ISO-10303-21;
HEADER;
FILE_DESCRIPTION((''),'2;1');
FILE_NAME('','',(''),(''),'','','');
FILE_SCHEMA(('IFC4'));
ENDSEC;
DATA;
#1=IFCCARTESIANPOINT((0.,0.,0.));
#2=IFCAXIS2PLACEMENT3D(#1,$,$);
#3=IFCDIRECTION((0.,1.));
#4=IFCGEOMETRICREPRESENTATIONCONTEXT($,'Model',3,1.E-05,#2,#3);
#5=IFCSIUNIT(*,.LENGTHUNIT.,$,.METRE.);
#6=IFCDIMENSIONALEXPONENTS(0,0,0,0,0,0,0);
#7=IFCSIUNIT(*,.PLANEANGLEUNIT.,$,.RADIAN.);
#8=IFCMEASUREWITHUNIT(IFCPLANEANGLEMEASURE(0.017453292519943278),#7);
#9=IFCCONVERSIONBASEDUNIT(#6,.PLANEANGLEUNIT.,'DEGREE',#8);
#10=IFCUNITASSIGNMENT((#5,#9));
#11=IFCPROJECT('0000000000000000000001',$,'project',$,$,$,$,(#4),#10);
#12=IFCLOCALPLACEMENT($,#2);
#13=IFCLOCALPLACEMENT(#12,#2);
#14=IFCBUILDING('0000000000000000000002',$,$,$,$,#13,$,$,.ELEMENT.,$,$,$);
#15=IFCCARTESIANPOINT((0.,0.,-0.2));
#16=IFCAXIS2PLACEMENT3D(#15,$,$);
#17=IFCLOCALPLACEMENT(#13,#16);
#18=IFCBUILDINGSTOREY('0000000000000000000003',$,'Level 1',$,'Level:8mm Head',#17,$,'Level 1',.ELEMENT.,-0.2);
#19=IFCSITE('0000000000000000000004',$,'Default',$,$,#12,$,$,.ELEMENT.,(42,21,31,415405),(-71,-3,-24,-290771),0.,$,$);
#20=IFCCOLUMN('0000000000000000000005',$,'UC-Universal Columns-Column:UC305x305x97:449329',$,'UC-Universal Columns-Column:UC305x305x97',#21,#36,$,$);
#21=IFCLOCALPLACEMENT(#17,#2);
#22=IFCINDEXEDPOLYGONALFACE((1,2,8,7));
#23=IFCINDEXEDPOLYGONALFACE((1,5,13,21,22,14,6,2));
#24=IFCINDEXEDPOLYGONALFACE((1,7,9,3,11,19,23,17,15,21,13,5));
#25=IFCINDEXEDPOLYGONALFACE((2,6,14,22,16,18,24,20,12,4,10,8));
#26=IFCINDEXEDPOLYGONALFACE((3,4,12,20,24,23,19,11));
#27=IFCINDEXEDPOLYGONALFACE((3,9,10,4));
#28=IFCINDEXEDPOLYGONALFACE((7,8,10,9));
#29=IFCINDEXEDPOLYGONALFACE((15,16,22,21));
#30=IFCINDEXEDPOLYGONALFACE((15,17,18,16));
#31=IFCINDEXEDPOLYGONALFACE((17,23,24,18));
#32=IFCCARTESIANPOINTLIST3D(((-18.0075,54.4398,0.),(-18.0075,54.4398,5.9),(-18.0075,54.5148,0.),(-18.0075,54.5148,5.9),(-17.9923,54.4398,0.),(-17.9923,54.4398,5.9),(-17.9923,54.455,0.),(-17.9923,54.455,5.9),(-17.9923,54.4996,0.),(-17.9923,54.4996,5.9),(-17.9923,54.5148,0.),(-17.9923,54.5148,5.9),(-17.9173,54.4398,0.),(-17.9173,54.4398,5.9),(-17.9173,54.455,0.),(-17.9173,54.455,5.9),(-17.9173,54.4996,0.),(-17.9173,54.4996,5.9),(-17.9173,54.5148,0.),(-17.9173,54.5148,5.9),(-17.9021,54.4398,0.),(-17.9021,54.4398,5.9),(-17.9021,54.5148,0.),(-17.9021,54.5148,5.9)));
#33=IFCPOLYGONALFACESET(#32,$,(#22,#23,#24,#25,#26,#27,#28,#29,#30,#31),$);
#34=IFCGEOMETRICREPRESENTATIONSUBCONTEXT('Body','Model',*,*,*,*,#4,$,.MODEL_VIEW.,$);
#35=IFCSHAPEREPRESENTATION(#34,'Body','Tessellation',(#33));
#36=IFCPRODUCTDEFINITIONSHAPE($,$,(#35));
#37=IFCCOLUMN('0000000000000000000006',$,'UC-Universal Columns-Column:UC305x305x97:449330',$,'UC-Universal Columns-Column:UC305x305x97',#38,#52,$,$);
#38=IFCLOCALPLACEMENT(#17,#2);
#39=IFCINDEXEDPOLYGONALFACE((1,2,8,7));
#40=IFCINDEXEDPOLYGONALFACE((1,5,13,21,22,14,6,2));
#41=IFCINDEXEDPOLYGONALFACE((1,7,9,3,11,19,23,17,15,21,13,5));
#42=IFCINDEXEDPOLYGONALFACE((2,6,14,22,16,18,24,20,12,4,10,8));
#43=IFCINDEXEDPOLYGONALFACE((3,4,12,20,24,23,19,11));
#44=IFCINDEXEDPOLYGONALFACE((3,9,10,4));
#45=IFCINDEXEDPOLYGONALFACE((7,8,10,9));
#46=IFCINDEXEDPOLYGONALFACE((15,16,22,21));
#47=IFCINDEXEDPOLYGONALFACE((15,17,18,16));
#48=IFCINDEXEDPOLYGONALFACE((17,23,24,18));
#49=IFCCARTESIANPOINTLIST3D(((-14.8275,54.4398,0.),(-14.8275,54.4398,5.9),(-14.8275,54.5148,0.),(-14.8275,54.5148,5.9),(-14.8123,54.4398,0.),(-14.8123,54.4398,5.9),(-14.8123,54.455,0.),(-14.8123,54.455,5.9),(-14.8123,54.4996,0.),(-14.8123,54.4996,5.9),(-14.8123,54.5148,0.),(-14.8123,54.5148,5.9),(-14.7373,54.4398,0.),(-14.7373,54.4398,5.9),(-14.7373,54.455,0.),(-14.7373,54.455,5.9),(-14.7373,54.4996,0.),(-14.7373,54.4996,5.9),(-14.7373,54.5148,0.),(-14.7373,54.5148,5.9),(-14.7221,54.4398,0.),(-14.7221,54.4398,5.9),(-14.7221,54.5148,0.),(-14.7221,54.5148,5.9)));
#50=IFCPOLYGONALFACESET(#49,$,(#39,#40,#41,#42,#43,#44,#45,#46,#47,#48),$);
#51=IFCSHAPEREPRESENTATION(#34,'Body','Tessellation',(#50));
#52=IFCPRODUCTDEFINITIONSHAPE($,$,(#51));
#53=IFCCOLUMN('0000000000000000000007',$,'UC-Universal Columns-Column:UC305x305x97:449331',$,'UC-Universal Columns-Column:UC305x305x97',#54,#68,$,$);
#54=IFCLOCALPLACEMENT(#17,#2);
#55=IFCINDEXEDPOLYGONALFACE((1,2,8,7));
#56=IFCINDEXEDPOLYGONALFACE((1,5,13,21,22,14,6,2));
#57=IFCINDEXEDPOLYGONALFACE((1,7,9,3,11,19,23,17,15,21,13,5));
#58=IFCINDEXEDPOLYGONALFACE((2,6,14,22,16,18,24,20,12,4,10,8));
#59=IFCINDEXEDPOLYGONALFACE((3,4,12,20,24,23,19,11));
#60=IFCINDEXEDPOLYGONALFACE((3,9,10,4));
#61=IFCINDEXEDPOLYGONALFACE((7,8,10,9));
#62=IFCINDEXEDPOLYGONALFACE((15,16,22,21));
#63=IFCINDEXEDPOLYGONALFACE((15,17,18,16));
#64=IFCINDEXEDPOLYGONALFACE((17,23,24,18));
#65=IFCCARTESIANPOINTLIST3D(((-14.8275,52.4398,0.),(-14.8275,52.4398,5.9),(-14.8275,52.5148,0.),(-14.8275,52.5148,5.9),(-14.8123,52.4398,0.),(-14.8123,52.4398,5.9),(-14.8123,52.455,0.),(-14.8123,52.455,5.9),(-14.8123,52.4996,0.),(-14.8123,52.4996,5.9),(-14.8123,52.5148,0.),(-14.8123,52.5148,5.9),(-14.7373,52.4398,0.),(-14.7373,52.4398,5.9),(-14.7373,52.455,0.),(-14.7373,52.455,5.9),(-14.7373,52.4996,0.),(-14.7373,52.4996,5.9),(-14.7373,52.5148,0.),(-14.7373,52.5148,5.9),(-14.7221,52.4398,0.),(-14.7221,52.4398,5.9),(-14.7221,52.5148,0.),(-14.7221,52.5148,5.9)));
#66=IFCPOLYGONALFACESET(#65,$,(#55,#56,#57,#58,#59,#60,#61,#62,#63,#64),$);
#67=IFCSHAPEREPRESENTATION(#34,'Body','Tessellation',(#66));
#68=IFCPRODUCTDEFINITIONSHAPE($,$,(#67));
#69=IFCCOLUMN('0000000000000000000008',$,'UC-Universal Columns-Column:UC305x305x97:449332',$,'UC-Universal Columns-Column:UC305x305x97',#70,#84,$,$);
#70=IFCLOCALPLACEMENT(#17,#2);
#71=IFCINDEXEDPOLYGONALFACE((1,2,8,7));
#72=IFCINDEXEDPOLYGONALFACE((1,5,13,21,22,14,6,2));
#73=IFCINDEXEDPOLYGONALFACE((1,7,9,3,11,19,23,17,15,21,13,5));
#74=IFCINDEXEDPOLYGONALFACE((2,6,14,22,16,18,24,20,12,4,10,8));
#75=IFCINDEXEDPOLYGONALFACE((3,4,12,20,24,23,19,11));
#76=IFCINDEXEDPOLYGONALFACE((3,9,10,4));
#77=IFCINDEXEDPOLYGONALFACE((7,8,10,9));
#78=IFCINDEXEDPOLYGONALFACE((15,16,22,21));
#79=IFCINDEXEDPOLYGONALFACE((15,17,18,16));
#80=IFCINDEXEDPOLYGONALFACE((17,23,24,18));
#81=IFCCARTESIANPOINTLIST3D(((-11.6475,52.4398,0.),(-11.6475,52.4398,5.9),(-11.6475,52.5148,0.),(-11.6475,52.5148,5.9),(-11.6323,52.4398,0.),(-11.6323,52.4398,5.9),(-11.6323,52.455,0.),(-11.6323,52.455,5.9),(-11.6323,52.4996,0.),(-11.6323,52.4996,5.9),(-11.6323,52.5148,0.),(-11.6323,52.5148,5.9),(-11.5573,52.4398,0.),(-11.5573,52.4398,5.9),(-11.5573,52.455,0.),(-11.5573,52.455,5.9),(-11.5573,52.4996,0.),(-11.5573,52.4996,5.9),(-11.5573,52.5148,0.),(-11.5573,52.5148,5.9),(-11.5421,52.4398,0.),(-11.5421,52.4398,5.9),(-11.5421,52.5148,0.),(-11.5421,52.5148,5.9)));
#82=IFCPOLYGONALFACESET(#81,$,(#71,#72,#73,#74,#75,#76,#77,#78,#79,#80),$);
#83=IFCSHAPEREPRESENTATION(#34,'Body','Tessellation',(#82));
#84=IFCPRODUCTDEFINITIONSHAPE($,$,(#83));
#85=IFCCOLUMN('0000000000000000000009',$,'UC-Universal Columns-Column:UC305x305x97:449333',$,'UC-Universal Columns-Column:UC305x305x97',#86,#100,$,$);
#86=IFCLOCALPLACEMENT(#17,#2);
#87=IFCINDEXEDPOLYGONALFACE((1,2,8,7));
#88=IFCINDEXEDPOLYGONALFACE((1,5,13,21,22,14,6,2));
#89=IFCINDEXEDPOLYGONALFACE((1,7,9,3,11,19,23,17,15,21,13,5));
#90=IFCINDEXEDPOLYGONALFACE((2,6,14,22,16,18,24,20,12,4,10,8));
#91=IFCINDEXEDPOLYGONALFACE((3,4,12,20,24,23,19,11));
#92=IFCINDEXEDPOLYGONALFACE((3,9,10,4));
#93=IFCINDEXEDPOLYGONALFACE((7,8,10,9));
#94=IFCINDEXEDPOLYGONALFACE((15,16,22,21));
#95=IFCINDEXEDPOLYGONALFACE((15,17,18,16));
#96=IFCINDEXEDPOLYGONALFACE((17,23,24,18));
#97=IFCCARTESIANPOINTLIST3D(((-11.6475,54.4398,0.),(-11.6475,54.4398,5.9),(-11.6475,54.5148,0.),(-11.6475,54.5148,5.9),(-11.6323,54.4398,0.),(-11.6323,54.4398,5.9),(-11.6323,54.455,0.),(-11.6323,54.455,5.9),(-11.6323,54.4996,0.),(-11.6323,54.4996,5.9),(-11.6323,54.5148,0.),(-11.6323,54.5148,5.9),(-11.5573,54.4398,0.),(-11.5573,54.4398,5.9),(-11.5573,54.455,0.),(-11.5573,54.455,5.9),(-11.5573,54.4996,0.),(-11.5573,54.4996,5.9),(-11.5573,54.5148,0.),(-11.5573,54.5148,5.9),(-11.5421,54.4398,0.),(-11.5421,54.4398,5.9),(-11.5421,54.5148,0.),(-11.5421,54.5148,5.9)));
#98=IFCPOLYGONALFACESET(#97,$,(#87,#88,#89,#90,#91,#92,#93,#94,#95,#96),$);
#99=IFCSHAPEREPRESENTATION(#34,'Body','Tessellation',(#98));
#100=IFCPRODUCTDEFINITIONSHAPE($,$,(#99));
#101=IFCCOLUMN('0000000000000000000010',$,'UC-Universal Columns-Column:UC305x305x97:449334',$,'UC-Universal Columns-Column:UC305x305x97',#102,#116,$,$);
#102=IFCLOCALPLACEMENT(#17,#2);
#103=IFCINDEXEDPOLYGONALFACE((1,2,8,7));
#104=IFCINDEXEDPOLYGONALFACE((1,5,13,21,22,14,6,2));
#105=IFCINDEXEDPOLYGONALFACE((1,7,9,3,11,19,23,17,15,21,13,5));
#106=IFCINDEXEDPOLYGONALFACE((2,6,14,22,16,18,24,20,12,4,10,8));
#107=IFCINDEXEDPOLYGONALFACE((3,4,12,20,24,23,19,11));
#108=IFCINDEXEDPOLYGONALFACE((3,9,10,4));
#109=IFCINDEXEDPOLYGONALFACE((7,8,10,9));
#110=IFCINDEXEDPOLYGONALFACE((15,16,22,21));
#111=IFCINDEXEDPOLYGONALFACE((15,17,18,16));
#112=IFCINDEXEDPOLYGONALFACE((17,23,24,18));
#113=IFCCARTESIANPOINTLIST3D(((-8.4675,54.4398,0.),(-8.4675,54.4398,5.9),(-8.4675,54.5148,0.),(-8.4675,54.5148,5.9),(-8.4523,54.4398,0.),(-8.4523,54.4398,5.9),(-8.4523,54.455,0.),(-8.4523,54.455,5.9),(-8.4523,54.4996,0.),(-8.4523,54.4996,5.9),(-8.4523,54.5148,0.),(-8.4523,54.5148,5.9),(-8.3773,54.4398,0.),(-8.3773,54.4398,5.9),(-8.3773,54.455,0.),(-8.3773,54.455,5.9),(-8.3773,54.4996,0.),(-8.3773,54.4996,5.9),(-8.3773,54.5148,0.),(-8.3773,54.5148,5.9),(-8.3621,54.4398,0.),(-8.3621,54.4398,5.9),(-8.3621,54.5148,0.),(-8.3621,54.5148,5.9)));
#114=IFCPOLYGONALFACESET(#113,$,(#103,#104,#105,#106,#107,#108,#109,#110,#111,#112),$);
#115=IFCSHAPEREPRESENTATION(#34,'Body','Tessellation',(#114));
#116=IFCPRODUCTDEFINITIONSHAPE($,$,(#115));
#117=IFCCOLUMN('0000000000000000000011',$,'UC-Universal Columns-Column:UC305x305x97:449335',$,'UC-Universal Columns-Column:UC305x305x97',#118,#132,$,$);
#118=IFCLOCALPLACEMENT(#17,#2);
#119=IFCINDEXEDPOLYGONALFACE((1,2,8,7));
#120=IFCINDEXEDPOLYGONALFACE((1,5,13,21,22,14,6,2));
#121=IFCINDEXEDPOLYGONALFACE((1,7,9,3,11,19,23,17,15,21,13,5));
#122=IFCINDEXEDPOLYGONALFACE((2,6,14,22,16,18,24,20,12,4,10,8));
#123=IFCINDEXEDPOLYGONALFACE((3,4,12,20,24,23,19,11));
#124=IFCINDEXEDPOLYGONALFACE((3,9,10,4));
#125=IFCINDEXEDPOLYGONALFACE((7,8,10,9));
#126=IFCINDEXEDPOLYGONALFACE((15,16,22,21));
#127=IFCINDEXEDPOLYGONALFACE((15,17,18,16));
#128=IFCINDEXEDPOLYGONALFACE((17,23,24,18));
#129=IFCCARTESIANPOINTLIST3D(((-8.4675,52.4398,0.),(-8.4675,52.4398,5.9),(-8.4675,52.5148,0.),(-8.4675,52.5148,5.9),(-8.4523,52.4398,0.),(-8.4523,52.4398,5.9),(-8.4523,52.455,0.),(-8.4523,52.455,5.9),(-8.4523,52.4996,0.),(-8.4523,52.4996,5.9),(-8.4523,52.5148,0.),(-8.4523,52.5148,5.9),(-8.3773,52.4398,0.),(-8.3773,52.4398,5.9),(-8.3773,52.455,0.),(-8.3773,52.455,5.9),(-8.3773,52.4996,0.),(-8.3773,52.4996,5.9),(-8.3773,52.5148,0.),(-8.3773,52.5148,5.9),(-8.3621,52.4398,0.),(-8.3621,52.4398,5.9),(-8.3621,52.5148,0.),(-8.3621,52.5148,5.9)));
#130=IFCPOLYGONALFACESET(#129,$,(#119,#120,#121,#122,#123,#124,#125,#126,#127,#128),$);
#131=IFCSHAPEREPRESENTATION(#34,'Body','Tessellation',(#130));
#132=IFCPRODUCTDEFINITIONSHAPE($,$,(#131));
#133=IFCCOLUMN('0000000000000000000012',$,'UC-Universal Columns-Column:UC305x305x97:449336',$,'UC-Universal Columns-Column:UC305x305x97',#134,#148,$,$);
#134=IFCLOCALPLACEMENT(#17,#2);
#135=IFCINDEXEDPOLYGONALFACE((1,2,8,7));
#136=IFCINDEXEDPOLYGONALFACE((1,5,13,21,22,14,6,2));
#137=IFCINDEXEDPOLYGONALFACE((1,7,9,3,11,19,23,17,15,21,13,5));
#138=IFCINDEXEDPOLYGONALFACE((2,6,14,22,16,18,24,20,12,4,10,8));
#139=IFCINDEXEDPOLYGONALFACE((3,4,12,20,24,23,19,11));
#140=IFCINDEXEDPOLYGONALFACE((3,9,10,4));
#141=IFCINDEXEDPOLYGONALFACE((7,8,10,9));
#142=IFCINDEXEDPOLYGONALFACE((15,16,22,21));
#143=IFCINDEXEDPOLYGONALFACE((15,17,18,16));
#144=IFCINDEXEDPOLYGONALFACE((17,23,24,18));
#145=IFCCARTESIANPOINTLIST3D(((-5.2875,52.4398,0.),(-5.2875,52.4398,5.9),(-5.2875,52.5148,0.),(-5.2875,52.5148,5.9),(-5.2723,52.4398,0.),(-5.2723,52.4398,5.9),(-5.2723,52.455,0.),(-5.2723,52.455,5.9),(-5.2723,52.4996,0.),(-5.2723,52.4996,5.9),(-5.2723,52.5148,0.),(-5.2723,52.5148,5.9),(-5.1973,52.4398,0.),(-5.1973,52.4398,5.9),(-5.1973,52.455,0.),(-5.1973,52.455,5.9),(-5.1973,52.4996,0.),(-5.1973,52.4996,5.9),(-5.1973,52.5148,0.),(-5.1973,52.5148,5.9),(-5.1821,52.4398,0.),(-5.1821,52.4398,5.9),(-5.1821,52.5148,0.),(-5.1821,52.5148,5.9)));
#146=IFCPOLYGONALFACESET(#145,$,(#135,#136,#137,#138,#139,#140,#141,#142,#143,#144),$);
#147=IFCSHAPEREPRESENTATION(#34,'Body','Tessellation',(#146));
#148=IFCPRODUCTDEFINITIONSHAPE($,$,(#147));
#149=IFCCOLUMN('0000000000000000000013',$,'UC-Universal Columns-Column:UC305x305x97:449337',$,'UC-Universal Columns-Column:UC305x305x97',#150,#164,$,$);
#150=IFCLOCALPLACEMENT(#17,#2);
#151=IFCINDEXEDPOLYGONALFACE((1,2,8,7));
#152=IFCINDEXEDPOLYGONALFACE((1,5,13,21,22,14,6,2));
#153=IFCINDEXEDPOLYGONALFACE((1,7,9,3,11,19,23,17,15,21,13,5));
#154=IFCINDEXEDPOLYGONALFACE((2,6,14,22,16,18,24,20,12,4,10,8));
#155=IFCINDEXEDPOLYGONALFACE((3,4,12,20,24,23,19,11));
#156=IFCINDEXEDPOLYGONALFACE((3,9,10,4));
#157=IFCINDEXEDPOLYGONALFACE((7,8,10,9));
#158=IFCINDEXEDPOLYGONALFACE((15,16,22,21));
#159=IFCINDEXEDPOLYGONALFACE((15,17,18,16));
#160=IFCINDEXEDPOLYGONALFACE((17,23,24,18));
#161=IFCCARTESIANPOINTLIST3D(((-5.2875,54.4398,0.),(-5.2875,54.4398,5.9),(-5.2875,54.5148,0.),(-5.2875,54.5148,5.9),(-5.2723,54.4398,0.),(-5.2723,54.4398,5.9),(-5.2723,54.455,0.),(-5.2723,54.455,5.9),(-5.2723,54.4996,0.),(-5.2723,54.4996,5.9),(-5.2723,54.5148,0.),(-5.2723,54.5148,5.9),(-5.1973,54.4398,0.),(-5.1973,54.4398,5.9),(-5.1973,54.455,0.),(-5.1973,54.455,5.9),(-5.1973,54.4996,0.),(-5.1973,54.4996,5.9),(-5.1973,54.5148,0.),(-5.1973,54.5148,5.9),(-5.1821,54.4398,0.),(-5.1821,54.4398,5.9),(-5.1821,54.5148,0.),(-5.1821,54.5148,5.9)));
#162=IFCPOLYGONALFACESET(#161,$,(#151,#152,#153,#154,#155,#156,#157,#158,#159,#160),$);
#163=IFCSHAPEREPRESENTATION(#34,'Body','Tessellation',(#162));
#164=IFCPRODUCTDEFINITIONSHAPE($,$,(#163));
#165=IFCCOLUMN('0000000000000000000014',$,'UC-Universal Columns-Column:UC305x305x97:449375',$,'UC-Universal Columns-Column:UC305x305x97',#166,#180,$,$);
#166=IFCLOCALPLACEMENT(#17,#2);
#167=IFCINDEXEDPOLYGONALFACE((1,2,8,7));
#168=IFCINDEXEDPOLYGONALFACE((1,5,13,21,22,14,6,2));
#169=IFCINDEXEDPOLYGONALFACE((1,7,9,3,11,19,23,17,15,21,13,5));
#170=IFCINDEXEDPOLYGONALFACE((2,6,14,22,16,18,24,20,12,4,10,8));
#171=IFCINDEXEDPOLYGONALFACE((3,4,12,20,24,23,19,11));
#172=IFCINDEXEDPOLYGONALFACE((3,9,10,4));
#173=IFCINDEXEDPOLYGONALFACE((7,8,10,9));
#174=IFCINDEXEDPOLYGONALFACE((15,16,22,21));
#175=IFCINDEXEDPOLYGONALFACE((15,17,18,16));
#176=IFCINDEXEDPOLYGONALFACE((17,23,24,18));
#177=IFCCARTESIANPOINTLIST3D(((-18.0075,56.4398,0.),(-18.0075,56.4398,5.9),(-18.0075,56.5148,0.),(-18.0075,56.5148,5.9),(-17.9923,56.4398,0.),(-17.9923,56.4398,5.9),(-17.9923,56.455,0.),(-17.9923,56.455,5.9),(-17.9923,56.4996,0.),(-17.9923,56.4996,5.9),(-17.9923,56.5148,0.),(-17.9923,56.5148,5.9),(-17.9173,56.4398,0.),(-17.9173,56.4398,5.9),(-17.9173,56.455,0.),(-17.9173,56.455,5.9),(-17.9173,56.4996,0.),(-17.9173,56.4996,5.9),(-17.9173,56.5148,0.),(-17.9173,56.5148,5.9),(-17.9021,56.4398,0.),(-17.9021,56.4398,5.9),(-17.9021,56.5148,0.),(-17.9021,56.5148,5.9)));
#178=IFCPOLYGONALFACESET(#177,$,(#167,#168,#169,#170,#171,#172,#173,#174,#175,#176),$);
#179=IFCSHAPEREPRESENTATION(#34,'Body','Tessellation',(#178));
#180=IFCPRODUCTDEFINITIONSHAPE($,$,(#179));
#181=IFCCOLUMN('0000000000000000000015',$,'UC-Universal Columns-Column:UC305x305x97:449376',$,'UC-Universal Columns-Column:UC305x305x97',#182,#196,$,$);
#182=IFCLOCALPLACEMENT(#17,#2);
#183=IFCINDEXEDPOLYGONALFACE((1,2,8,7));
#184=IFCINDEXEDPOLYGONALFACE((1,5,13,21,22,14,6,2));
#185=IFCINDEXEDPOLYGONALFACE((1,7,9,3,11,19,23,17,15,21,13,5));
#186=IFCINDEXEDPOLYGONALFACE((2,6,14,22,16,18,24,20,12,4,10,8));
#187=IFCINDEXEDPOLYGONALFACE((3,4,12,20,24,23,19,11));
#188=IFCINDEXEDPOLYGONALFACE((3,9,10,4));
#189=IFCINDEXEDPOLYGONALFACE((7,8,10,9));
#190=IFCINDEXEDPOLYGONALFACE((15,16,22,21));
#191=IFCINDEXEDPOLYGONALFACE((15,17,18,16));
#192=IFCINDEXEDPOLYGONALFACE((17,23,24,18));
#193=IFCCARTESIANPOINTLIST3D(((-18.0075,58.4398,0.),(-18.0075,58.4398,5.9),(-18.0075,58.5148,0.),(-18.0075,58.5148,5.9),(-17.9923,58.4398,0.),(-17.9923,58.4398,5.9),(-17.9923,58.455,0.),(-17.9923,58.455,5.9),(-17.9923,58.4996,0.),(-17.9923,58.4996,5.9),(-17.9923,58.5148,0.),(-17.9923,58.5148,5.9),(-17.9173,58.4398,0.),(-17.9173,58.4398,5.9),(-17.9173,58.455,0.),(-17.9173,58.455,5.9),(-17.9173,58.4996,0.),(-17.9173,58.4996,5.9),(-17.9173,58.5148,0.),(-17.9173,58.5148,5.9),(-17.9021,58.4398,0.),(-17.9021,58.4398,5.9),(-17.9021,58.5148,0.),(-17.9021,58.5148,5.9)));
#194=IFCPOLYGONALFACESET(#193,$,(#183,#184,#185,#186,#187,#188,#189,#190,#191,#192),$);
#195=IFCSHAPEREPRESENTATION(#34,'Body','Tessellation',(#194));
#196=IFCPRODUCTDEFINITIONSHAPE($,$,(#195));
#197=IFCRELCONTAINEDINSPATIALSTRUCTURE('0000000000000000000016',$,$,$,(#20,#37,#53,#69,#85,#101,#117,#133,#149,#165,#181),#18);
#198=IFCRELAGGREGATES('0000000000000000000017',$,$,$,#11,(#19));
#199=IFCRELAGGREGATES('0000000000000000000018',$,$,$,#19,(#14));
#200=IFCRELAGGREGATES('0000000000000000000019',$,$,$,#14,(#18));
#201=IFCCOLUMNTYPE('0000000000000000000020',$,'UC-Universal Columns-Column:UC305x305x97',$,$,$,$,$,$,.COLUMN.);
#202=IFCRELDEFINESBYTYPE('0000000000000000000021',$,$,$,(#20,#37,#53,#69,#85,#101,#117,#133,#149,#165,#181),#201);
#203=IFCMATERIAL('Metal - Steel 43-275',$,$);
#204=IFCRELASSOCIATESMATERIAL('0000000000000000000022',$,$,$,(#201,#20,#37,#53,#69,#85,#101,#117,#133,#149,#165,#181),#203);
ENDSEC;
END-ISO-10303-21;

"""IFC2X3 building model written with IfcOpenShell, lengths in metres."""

from ifc_helpers import new_model, entity, si_unit, converted_unit, direction, frame, frame_2d, origin, place, context, subcontext, project, spatial, polyline, circle_curve, parameter, trimmed, segment, composite_curve, outline, extrude, source, transform, mapped, material, type_object, type_shapes, element, save


model = new_model("IFC2X3")

# Units and contexts
model_context = context("Model", 3, precision=1e-05, world=origin(), true_north=direction((0.0, 1.0)))
body_context = subcontext(model_context, "Body", "Model", "MODEL_VIEW")
ifc_project = project(units=[si_unit("LENGTHUNIT", "METRE"), converted_unit("PLANEANGLEUNIT", "DEGREE", entity("IfcPlaneAngleMeasure", 0.017453292519943278), si_unit("PLANEANGLEUNIT", "RADIAN"), dimensions=[0, 0, 0, 0, 0, 0, 0])], contexts=[model_context])

# Site, building, storey
site_placement = place(None, origin())
site = spatial("IfcSite", under=ifc_project, at=site_placement, Name="Default", CompositionType="ELEMENT", RefLatitude=(42, 21, 31, 415405), RefLongitude=(-71, -3, -24, -290771), RefElevation=0.0)
building_placement = place(site_placement, origin())
building = spatial("IfcBuilding", under=site, at=building_placement, CompositionType="ELEMENT")
storey_placement = place(building_placement, frame((0.0, 0.0, -0.2)))
storey = spatial("IfcBuildingStorey", under=building, at=storey_placement, Name="Level 1", ObjectType="Level:8mm Head", LongName="Level 1", CompositionType="ELEMENT", Elevation=-0.2)

# Columns
ifc_material = material(Name="Metal - Steel 43-275")
column_type = type_object("IfcColumnType", Name="UC-Universal Columns-Column:UC305x305x97", PredefinedType="COLUMN", material=ifc_material)
shared_shape = source(origin(), body_context, "Body", "SweptSolid", [
    extrude(outline(composite_curve([segment(polyline([(-0.0375, -0.0375), (0.0375, -0.0375)]), True, "CONTINUOUS"), segment(polyline([(0.0375, -0.0375), (0.0527, -0.0375)]), True, "CONTINUOUS"), segment(trimmed(circle_curve(frame_2d((0.0527, -0.0223), x_axis=(-1.0, 0.0)), 0.0152), [parameter(0.0)], [parameter(90.0)], True, "PARAMETER"), False, "CONTINUOUS"), segment(polyline([(0.0375, -0.0223), (0.0375, 0.0223)]), True, "CONTINUOUS"), segment(trimmed(circle_curve(frame_2d((0.0527, 0.0223), x_axis=(-1.0, 0.0)), 0.0152), [parameter(270.0)], [parameter(0.0)], True, "PARAMETER"), False, "CONTINUOUS"), segment(polyline([(0.0527, 0.0375), (0.0375, 0.0375)]), True, "CONTINUOUS"), segment(polyline([(0.0375, 0.0375), (-0.0375, 0.0375)]), True, "CONTINUOUS"), segment(polyline([(-0.0375, 0.0375), (-0.0527, 0.0375)]), True, "CONTINUOUS"), segment(trimmed(circle_curve(frame_2d((-0.0527, 0.0223), x_axis=(-1.0, 0.0)), 0.0152), [parameter(180.0)], [parameter(270.0)], True, "PARAMETER"), False, "CONTINUOUS"), segment(polyline([(-0.0375, 0.0223), (-0.0375, -0.0223)]), True, "CONTINUOUS"), segment(trimmed(circle_curve(frame_2d((-0.0527, -0.0223), x_axis=(-1.0, 0.0)), 0.0152), [parameter(90.0)], [parameter(180.0)], True, "PARAMETER"), False, "CONTINUOUS"), segment(polyline([(-0.0527, -0.0375), (-0.0375, -0.0375)]), True, "CONTINUOUS")], self_intersect=False)), frame((0.0, 0.0, -0.2), z_axis=(0.0, 0.0, 1.0), x_axis=(-1.0, 0.0, 0.0)), (0.0, 0.0, 1.0), 5.9),
])
type_shapes(column_type, [shared_shape])
for number, where, z_axis, x_axis, name in (
    (1, (-17.9548, 54.4773, 0.2), (0.0, 0.0, 1.0), (-1.0, 0.0, 0.0), "UC-Universal Columns-Column:UC305x305x97:449329"),
    (2, (-14.7748, 54.4773, 0.2), (0.0, 0.0, 1.0), (-1.0, 0.0, 0.0), "UC-Universal Columns-Column:UC305x305x97:449330"),
    (3, (-14.7748, 52.4773, 0.2), (0.0, 0.0, 1.0), (-1.0, 0.0, 0.0), "UC-Universal Columns-Column:UC305x305x97:449331"),
    (4, (-11.5948, 52.4773, 0.2), (0.0, 0.0, 1.0), (-1.0, 0.0, 0.0), "UC-Universal Columns-Column:UC305x305x97:449332"),
    (5, (-11.5948, 54.4773, 0.2), (0.0, 0.0, 1.0), (-1.0, 0.0, 0.0), "UC-Universal Columns-Column:UC305x305x97:449333"),
    (6, (-8.4148, 54.4773, 0.2), (0.0, 0.0, 1.0), (-1.0, 0.0, 0.0), "UC-Universal Columns-Column:UC305x305x97:449334"),
    (7, (-8.4148, 52.4773, 0.2), (0.0, 0.0, 1.0), (-1.0, 0.0, 0.0), "UC-Universal Columns-Column:UC305x305x97:449335"),
    (8, (-5.2348, 52.4773, 0.2), (0.0, 0.0, 1.0), (-1.0, 0.0, 0.0), "UC-Universal Columns-Column:UC305x305x97:449336"),
    (9, (-5.2348, 54.4773, 0.2), (0.0, 0.0, 1.0), (-1.0, 0.0, 0.0), "UC-Universal Columns-Column:UC305x305x97:449337"),
    (10, (-17.9548, 56.4773, 0.2), (0.0, 0.0, 1.0), (-1.0, 0.0, 0.0), "UC-Universal Columns-Column:UC305x305x97:449375"),
    (11, (-17.9548, 58.4773, 0.2), (0.0, 0.0, 1.0), (-1.0, 0.0, 0.0), "UC-Universal Columns-Column:UC305x305x97:449376"),
):
    element("IfcColumn", number, at=place(storey_placement, frame(where, z_axis=z_axis, x_axis=x_axis)), inside=storey, type_object=column_type, material=ifc_material, Name=name, ObjectType="UC-Universal Columns-Column:UC305x305x97", context=body_context, shape_type="MappedRepresentation", body=[
        mapped(shared_shape, transform((0.0, 0.0, 0.0), scale=1.0)),
    ])

save(model, "model.ifc")
